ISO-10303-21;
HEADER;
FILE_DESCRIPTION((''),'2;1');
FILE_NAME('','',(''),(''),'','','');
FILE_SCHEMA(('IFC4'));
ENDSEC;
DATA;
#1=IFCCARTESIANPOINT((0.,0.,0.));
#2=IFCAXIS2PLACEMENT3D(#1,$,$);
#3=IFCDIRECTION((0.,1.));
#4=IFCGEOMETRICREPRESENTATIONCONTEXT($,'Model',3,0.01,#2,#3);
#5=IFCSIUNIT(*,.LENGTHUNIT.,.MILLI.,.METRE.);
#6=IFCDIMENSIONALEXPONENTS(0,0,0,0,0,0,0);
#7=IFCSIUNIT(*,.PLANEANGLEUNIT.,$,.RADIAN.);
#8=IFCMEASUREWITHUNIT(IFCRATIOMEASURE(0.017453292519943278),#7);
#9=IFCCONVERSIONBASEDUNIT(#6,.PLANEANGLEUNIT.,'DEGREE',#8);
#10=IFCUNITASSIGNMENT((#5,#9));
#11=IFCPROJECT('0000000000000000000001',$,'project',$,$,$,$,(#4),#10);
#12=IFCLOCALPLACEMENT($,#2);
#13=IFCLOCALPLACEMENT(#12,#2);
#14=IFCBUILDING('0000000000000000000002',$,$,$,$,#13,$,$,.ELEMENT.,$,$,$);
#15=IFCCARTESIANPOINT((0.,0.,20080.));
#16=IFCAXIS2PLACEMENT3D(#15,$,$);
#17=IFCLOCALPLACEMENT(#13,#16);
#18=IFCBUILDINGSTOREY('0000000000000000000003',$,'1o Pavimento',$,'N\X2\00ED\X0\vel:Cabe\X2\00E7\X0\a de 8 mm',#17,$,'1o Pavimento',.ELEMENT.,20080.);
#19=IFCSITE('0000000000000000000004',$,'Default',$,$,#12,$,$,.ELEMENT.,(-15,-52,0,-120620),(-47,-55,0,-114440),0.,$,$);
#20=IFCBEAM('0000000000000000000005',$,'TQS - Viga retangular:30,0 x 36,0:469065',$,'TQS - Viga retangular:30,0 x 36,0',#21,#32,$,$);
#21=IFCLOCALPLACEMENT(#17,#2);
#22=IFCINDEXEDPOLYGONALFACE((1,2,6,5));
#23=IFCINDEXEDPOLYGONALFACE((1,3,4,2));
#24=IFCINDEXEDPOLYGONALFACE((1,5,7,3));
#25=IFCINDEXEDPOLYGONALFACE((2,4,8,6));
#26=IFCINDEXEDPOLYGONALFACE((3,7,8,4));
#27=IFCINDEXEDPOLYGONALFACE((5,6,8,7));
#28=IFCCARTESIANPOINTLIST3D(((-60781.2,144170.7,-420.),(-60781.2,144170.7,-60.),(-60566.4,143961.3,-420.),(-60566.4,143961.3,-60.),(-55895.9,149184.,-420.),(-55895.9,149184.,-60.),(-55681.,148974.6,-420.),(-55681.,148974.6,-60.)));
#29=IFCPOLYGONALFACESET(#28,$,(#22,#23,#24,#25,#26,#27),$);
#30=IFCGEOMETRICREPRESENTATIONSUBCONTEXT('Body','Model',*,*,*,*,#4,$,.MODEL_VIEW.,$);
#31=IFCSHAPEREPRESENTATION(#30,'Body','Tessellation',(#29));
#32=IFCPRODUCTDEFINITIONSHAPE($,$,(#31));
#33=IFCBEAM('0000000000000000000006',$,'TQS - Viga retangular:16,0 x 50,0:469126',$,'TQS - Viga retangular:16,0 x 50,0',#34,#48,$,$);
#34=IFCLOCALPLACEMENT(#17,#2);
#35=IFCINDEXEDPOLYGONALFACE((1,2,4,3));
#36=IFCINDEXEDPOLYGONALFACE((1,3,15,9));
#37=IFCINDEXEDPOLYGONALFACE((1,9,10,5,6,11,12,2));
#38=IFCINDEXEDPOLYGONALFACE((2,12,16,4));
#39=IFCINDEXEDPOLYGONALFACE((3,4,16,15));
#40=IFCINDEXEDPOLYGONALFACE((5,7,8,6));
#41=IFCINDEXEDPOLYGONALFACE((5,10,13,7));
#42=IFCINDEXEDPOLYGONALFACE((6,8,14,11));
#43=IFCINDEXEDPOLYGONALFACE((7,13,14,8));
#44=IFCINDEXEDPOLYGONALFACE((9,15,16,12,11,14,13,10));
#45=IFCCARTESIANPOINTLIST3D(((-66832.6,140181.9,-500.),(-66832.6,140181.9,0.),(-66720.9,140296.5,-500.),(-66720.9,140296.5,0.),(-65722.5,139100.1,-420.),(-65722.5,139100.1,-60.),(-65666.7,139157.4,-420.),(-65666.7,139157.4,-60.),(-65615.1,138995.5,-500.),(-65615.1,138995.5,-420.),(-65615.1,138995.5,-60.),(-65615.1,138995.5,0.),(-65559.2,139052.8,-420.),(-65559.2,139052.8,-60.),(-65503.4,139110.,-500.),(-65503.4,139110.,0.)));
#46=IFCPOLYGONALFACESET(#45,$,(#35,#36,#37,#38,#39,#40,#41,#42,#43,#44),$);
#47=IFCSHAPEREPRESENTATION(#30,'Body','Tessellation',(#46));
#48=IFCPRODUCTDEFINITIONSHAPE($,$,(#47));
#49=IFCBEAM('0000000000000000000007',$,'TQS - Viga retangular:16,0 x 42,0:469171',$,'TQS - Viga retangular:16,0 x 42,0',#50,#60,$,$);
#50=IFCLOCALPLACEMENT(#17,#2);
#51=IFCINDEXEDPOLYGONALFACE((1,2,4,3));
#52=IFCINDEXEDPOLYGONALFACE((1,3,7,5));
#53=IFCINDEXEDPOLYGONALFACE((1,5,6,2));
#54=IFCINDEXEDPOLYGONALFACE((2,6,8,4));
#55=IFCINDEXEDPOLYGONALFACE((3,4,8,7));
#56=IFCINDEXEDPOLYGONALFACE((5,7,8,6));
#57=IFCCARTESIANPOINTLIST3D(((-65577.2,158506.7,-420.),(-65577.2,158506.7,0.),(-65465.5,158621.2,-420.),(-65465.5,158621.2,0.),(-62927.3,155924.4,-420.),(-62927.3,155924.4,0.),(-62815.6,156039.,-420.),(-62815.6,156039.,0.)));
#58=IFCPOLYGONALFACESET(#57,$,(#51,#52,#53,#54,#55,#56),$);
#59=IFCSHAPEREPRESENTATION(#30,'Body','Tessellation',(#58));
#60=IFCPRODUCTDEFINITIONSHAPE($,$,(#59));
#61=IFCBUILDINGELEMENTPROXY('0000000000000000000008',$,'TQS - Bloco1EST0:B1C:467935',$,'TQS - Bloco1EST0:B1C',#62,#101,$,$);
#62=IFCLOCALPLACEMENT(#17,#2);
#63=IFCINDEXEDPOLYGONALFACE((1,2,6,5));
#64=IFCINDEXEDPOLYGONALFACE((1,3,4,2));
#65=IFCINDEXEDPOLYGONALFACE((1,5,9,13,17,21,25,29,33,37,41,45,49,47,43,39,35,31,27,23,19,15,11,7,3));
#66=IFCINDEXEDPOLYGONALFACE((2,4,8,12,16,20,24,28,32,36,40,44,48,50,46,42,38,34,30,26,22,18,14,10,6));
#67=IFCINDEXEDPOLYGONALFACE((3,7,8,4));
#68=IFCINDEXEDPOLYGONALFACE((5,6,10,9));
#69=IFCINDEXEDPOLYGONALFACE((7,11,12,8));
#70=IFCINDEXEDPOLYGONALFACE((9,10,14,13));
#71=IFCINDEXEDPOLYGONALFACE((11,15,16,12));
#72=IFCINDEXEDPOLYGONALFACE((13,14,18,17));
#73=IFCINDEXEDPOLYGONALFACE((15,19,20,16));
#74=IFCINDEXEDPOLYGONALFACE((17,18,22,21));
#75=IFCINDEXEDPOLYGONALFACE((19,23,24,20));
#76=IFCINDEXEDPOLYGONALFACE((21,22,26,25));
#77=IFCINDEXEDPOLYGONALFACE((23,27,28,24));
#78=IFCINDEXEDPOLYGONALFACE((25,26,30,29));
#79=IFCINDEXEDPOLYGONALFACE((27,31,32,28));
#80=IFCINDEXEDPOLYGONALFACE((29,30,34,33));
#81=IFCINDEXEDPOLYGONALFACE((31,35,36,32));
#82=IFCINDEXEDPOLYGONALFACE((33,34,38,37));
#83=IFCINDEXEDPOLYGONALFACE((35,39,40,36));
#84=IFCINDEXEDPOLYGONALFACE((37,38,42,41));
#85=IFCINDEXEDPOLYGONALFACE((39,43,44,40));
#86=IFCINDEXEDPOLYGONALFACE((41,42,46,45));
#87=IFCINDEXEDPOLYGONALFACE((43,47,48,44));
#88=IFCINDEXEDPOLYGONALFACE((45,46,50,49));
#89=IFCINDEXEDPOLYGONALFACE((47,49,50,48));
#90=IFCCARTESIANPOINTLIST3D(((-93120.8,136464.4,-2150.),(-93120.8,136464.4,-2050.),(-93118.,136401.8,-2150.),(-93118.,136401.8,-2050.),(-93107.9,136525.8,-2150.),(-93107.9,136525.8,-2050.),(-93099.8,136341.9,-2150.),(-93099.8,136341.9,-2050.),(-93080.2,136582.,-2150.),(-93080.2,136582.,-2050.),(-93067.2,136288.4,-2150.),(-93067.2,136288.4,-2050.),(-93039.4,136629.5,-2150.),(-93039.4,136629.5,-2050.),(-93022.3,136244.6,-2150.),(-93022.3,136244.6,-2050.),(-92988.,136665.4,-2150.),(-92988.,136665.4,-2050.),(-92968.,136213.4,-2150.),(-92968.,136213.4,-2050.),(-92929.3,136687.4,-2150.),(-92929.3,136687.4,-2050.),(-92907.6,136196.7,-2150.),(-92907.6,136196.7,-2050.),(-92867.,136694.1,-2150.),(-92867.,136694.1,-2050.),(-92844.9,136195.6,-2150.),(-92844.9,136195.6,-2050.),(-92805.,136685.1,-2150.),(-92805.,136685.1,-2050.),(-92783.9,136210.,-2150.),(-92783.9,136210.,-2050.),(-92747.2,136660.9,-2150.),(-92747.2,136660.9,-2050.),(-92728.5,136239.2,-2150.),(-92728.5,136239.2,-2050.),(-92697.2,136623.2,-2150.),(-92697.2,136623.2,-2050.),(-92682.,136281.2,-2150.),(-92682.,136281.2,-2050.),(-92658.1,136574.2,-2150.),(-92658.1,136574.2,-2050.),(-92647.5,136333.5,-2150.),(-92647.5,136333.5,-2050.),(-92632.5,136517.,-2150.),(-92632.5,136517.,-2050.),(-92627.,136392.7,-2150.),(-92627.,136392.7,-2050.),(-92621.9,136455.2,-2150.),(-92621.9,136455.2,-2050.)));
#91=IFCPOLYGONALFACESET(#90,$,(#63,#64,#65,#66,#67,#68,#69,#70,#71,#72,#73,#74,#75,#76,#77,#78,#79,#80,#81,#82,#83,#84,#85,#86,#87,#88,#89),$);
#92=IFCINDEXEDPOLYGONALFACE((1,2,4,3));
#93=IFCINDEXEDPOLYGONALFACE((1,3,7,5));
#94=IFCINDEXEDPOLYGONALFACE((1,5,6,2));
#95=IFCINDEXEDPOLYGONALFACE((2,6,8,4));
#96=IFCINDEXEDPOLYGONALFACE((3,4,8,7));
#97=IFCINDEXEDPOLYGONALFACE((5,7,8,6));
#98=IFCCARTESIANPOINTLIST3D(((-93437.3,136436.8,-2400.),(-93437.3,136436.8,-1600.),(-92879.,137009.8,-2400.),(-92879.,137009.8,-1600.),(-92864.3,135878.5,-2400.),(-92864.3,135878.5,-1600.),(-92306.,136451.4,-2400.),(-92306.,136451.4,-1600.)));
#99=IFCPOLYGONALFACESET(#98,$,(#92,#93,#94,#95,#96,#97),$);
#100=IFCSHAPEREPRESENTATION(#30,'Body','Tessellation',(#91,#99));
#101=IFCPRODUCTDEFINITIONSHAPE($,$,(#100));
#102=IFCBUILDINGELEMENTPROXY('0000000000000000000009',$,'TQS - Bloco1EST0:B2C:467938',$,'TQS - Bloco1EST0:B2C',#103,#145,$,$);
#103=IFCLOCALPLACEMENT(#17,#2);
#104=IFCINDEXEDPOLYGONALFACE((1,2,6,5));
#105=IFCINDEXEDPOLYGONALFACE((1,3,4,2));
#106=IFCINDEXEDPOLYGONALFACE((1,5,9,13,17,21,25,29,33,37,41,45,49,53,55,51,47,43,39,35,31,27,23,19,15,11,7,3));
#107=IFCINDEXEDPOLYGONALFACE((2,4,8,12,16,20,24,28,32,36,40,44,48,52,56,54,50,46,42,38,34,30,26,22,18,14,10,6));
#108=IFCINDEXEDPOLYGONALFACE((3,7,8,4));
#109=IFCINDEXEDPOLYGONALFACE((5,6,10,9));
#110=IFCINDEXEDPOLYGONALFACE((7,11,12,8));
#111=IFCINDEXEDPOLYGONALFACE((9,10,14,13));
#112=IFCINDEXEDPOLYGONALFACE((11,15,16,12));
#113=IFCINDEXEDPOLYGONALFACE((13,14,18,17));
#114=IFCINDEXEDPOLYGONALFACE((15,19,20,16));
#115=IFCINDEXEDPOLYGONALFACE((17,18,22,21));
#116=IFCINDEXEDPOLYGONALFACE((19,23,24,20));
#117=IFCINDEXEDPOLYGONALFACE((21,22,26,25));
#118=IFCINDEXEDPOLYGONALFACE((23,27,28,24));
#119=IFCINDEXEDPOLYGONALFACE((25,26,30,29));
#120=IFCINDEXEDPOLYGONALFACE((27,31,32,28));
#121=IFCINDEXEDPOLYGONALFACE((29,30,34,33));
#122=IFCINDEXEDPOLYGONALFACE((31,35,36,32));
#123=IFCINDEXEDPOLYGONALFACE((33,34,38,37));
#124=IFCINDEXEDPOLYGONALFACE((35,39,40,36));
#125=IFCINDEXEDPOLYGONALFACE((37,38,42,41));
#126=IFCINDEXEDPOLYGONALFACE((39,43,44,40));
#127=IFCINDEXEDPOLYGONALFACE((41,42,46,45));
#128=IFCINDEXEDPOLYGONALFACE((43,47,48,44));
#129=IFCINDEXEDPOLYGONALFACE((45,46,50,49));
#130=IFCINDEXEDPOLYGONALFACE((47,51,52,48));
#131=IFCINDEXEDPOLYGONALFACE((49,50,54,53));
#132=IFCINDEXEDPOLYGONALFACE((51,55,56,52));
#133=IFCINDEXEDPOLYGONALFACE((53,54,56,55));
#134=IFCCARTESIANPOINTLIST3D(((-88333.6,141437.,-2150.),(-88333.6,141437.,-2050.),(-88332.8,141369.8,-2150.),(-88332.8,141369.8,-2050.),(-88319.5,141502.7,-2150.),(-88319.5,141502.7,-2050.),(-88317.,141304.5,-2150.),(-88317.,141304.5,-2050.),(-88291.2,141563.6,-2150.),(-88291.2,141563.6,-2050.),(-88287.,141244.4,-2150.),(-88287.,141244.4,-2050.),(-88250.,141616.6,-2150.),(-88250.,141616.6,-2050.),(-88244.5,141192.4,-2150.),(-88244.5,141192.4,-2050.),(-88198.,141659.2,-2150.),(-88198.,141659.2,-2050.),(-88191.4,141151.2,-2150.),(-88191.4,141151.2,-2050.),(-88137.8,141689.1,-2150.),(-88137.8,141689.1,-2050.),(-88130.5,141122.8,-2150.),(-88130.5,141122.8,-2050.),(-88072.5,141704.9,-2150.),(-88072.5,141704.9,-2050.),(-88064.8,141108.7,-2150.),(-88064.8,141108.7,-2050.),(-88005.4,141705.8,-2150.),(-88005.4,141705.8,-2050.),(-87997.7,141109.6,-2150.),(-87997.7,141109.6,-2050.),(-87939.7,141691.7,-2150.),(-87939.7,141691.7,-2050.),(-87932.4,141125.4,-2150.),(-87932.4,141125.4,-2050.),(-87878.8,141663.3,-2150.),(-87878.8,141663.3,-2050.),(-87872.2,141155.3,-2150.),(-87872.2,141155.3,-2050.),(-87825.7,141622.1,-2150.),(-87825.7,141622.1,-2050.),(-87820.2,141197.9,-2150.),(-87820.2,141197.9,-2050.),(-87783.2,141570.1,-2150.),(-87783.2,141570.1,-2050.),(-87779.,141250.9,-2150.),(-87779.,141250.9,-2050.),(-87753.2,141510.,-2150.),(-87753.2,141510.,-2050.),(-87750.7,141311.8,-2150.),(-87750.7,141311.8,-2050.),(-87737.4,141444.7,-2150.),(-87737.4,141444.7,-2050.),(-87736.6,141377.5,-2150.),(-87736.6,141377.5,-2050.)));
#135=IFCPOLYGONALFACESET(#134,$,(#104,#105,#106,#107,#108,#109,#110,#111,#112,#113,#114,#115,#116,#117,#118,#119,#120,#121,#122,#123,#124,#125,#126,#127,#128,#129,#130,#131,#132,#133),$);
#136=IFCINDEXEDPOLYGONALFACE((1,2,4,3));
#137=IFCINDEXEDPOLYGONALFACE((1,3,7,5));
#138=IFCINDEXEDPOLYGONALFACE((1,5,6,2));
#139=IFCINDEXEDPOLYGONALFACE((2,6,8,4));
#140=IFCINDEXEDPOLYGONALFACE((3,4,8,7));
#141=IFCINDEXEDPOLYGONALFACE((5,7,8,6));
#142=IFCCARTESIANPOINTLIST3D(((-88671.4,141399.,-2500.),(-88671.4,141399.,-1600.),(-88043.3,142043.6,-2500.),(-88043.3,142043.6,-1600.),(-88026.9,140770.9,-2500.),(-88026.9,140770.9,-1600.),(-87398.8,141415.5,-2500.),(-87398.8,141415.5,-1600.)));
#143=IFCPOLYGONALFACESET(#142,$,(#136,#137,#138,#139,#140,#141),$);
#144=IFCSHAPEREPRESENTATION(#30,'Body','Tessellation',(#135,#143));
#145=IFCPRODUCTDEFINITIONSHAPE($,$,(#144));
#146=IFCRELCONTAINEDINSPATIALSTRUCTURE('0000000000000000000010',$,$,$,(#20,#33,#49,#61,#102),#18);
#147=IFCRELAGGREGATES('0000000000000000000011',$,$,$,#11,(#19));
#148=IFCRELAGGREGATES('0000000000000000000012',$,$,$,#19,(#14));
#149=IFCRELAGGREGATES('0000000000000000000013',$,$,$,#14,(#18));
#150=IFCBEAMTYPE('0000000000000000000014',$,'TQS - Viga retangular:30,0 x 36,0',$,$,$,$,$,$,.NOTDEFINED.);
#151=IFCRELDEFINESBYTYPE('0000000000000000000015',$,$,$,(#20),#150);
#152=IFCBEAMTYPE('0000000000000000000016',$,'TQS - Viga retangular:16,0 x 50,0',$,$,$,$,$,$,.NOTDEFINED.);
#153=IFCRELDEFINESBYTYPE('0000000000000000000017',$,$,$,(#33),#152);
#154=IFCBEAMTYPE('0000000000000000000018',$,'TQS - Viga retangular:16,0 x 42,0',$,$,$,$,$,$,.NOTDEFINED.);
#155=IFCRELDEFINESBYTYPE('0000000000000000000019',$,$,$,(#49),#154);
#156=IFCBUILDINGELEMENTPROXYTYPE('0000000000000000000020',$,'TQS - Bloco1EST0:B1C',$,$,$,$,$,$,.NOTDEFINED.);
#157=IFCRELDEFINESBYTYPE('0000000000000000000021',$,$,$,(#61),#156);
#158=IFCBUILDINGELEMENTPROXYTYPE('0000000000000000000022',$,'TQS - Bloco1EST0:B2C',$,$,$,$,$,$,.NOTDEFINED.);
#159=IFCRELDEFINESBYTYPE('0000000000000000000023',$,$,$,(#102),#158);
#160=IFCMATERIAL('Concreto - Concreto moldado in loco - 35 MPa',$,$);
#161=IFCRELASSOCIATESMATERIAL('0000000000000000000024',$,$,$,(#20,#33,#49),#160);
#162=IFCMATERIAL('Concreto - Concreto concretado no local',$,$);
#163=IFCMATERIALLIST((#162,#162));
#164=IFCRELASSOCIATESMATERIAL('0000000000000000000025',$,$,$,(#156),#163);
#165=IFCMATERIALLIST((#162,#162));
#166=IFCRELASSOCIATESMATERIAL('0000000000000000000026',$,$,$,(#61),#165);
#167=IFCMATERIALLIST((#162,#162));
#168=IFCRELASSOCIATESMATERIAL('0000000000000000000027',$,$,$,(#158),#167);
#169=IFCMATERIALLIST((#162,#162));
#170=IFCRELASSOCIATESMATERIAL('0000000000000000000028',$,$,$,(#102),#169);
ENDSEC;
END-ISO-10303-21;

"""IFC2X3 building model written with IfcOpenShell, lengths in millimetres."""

from ifc_helpers import new_model, entity, si_unit, converted_unit, direction, frame, frame_2d, origin, origin_2d_with_axis, place, context, subcontext, project, spatial, polyline, rectangle, circle, extrude, boolean, clip, bounded_halfspace, source, transform, mapped, material, material_list, type_object, type_shapes, element, save


model = new_model("IFC2X3")

# Units and contexts
model_context = context("Model", 3, precision=0.01, world=origin(), true_north=direction((0.0, 1.0)))
body_context = subcontext(model_context, "Body", "Model", "MODEL_VIEW")
ifc_project = project(units=[si_unit("LENGTHUNIT", "METRE", prefix="MILLI"), converted_unit("PLANEANGLEUNIT", "DEGREE", entity("IfcRatioMeasure", 0.017453292519943278), si_unit("PLANEANGLEUNIT", "RADIAN"), dimensions=[0, 0, 0, 0, 0, 0, 0])], contexts=[model_context])

# Site, building, storey
site_placement = place(None, origin())
site = spatial("IfcSite", under=ifc_project, at=site_placement, Name="Default", CompositionType="ELEMENT", RefLatitude=(-15, -52, 0, -120620), RefLongitude=(-47, -55, 0, -114440), RefElevation=0.0)
building_placement = place(site_placement, origin())
building = spatial("IfcBuilding", under=site, at=building_placement, CompositionType="ELEMENT")
storey_placement = place(building_placement, frame((0.0, 0.0, 20080.0)))
storey = spatial("IfcBuildingStorey", under=building, at=storey_placement, Name="1o Pavimento", ObjectType="Nível:Cabeça de 8 mm", LongName="1o Pavimento", CompositionType="ELEMENT", Elevation=20080.0)

# Beams
ifc_material_1 = material(Name="Concreto - Concreto moldado in loco - 35 MPa")
beam_type_1 = type_object("IfcBeamType", Name="TQS - Viga retangular:30,0 x 36,0", PredefinedType="NOTDEFINED")
beam_1_placement = place(storey_placement, frame((-60673.8, 144066.0, -60.0), z_axis=(0.0, 0.0, 1.0), x_axis=(0.69791, 0.716186, 0.0)))
element("IfcBeam", 1, at=beam_1_placement, inside=storey, type_object=beam_type_1, material=ifc_material_1, Name="TQS - Viga retangular:30,0 x 36,0:469065", ObjectType="TQS - Viga retangular:30,0 x 36,0", context=body_context, shape_type="SweptSolid", body=[
    extrude(rectangle(XDim=360.0, YDim=300.0, at=frame_2d((0.0, 0.0), x_axis=(1.0, 0.0))), frame((0.0, 0.0, -180.0), z_axis=(1.0, 0.0, 0.0), x_axis=(0.0, 0.0, -1.0)), (0.0, 0.0, 1.0), 7000.0),
])
beam_type_2 = type_object("IfcBeamType", Name="TQS - Viga retangular:16,0 x 50,0", PredefinedType="NOTDEFINED")
beam_2_placement = place(storey_placement, frame((-65559.2, 139052.8, 0.0), z_axis=(0.0, 0.0, 1.0), x_axis=(-0.71618, 0.697915, 0.0)))
element("IfcBeam", 2, at=beam_2_placement, inside=storey, type_object=beam_type_2, material=ifc_material_1, Name="TQS - Viga retangular:16,0 x 50,0:469126", ObjectType="TQS - Viga retangular:16,0 x 50,0", context=body_context, shape_type="SweptSolid", body=[
    boolean("DIFFERENCE", clip(extrude(rectangle(XDim=500.0, YDim=160.0, at=frame_2d((0.0, 0.0), x_axis=(1.0, 0.0))), frame((0.0, 0.0, -250.0), z_axis=(1.0, 0.0, 0.0), x_axis=(0.0, 0.0, -1.0)), (0.0, 0.0, 1.0), 1700.0), bounded_halfspace(frame((150.0, 0.0, -420.0), z_axis=(-1.0, 0.0, 0.0), x_axis=(0.0, 1.0, 0.0)), False, frame((0.0, 0.0, -250.0), z_axis=(1.0, 0.0, 0.0), x_axis=(0.0, 0.0, -1.0)), polyline([(170.0, 0.0), (-190.0, 0.0), (-190.0, 80.0), (-90.0, 80.0), (170.0, 80.0), (170.0, 0.0)]))), extrude(rectangle(XDim=360.0, YDim=80.0, at=frame_2d((0.0, 0.0), x_axis=(0.0, 1.0))), frame((0.0, 40.0, -240.0), z_axis=(-1.0, 0.0, 0.0), x_axis=(0.0, -1.0, 0.0)), (0.0, 0.0, -1.0), 150.0)),
])
beam_type_3 = type_object("IfcBeamType", Name="TQS - Viga retangular:16,0 x 42,0", PredefinedType="NOTDEFINED")
beam_3_placement = place(storey_placement, frame((-62814.2, 155925.8, 0.0), z_axis=(0.0, 0.0, 1.0), x_axis=(-0.71618, 0.697915, 0.0)))
element("IfcBeam", 3, at=beam_3_placement, inside=storey, type_object=beam_type_3, material=ifc_material_1, Name="TQS - Viga retangular:16,0 x 42,0:469171", ObjectType="TQS - Viga retangular:16,0 x 42,0", context=body_context, shape_type="SweptSolid", body=[
    extrude(rectangle(XDim=420.0, YDim=160.0, at=frame_2d((0.0, 0.0), x_axis=(1.0, 0.0))), frame((80.0, 0.0, -210.0), z_axis=(1.0, 0.0, 0.0), x_axis=(0.0, 0.0, -1.0)), (0.0, 0.0, 1.0), 3700.0),
])

# Building element proxies
ifc_material_2 = material(Name="Concreto - Concreto concretado no local")
ifc_material_list_1 = material_list([ifc_material_2, ifc_material_2])
ifc_material_list_2 = material_list([ifc_material_2, ifc_material_2])
building_element_proxy_type_1 = type_object("IfcBuildingElementProxyType", Name="TQS - Bloco1EST0:B1C", PredefinedType="NOTDEFINED", material=ifc_material_list_2)
shared_shape_1 = source(origin(), body_context, "Body", "SweptSolid", [
    extrude(circle(Radius=250.0, at=frame_2d((0.0, 0.0), x_axis=(1.0, 0.0))), frame((0.0, 0.0, -550.0)), (0.0, 0.0, 1.0), 100.0),
    extrude(rectangle(XDim=800.0, YDim=800.0, at=origin_2d_with_axis()), frame((0.0, 0.0, -800.0), z_axis=(0.0, 0.0, 1.0), x_axis=(-1.0, 0.0, 0.0)), (0.0, 0.0, 1.0), 800.0),
])
type_shapes(building_element_proxy_type_1, [shared_shape_1])
proxy_1_placement = place(storey_placement, frame((-92871.7, 136444.1, -1600.0), z_axis=(0.0, 0.0, 1.0), x_axis=(0.697915, 0.71618, 0.0)))
element("IfcBuildingElementProxy", 4, at=proxy_1_placement, inside=storey, type_object=building_element_proxy_type_1, material=ifc_material_list_1, Name="TQS - Bloco1EST0:B1C:467935", ObjectType="TQS - Bloco1EST0:B1C", context=body_context, shape_type="MappedRepresentation", body=[
    mapped(shared_shape_1, transform((0.0, 0.0, 0.0), scale=1.0)),
])
ifc_material_list_3 = material_list([ifc_material_2, ifc_material_2])
ifc_material_list_4 = material_list([ifc_material_2, ifc_material_2])
building_element_proxy_type_2 = type_object("IfcBuildingElementProxyType", Name="TQS - Bloco1EST0:B2C", PredefinedType="NOTDEFINED", material=ifc_material_list_4)
shared_shape_2 = source(origin(), body_context, "Body", "SweptSolid", [
    extrude(circle(Radius=300.0, at=frame_2d((0.0, 0.0), x_axis=(1.0, 0.0))), frame((0.0, 0.0, -550.0)), (0.0, 0.0, 1.0), 100.0),
    extrude(rectangle(XDim=900.0, YDim=900.0, at=origin_2d_with_axis()), frame((0.0, 0.0, -900.0), z_axis=(0.0, 0.0, 1.0), x_axis=(-1.0, 0.0, 0.0)), (0.0, 0.0, 1.0), 900.0),
])
type_shapes(building_element_proxy_type_2, [shared_shape_2])
proxy_2_placement = place(storey_placement, frame((-88035.1, 141407.3, -1600.0), z_axis=(0.0, 0.0, 1.0), x_axis=(0.697915, 0.71618, 0.0)))
element("IfcBuildingElementProxy", 5, at=proxy_2_placement, inside=storey, type_object=building_element_proxy_type_2, material=ifc_material_list_3, Name="TQS - Bloco1EST0:B2C:467938", ObjectType="TQS - Bloco1EST0:B2C", context=body_context, shape_type="MappedRepresentation", body=[
    mapped(shared_shape_2, transform((0.0, 0.0, 0.0), scale=1.0)),
])

save(model, "model.ifc")
